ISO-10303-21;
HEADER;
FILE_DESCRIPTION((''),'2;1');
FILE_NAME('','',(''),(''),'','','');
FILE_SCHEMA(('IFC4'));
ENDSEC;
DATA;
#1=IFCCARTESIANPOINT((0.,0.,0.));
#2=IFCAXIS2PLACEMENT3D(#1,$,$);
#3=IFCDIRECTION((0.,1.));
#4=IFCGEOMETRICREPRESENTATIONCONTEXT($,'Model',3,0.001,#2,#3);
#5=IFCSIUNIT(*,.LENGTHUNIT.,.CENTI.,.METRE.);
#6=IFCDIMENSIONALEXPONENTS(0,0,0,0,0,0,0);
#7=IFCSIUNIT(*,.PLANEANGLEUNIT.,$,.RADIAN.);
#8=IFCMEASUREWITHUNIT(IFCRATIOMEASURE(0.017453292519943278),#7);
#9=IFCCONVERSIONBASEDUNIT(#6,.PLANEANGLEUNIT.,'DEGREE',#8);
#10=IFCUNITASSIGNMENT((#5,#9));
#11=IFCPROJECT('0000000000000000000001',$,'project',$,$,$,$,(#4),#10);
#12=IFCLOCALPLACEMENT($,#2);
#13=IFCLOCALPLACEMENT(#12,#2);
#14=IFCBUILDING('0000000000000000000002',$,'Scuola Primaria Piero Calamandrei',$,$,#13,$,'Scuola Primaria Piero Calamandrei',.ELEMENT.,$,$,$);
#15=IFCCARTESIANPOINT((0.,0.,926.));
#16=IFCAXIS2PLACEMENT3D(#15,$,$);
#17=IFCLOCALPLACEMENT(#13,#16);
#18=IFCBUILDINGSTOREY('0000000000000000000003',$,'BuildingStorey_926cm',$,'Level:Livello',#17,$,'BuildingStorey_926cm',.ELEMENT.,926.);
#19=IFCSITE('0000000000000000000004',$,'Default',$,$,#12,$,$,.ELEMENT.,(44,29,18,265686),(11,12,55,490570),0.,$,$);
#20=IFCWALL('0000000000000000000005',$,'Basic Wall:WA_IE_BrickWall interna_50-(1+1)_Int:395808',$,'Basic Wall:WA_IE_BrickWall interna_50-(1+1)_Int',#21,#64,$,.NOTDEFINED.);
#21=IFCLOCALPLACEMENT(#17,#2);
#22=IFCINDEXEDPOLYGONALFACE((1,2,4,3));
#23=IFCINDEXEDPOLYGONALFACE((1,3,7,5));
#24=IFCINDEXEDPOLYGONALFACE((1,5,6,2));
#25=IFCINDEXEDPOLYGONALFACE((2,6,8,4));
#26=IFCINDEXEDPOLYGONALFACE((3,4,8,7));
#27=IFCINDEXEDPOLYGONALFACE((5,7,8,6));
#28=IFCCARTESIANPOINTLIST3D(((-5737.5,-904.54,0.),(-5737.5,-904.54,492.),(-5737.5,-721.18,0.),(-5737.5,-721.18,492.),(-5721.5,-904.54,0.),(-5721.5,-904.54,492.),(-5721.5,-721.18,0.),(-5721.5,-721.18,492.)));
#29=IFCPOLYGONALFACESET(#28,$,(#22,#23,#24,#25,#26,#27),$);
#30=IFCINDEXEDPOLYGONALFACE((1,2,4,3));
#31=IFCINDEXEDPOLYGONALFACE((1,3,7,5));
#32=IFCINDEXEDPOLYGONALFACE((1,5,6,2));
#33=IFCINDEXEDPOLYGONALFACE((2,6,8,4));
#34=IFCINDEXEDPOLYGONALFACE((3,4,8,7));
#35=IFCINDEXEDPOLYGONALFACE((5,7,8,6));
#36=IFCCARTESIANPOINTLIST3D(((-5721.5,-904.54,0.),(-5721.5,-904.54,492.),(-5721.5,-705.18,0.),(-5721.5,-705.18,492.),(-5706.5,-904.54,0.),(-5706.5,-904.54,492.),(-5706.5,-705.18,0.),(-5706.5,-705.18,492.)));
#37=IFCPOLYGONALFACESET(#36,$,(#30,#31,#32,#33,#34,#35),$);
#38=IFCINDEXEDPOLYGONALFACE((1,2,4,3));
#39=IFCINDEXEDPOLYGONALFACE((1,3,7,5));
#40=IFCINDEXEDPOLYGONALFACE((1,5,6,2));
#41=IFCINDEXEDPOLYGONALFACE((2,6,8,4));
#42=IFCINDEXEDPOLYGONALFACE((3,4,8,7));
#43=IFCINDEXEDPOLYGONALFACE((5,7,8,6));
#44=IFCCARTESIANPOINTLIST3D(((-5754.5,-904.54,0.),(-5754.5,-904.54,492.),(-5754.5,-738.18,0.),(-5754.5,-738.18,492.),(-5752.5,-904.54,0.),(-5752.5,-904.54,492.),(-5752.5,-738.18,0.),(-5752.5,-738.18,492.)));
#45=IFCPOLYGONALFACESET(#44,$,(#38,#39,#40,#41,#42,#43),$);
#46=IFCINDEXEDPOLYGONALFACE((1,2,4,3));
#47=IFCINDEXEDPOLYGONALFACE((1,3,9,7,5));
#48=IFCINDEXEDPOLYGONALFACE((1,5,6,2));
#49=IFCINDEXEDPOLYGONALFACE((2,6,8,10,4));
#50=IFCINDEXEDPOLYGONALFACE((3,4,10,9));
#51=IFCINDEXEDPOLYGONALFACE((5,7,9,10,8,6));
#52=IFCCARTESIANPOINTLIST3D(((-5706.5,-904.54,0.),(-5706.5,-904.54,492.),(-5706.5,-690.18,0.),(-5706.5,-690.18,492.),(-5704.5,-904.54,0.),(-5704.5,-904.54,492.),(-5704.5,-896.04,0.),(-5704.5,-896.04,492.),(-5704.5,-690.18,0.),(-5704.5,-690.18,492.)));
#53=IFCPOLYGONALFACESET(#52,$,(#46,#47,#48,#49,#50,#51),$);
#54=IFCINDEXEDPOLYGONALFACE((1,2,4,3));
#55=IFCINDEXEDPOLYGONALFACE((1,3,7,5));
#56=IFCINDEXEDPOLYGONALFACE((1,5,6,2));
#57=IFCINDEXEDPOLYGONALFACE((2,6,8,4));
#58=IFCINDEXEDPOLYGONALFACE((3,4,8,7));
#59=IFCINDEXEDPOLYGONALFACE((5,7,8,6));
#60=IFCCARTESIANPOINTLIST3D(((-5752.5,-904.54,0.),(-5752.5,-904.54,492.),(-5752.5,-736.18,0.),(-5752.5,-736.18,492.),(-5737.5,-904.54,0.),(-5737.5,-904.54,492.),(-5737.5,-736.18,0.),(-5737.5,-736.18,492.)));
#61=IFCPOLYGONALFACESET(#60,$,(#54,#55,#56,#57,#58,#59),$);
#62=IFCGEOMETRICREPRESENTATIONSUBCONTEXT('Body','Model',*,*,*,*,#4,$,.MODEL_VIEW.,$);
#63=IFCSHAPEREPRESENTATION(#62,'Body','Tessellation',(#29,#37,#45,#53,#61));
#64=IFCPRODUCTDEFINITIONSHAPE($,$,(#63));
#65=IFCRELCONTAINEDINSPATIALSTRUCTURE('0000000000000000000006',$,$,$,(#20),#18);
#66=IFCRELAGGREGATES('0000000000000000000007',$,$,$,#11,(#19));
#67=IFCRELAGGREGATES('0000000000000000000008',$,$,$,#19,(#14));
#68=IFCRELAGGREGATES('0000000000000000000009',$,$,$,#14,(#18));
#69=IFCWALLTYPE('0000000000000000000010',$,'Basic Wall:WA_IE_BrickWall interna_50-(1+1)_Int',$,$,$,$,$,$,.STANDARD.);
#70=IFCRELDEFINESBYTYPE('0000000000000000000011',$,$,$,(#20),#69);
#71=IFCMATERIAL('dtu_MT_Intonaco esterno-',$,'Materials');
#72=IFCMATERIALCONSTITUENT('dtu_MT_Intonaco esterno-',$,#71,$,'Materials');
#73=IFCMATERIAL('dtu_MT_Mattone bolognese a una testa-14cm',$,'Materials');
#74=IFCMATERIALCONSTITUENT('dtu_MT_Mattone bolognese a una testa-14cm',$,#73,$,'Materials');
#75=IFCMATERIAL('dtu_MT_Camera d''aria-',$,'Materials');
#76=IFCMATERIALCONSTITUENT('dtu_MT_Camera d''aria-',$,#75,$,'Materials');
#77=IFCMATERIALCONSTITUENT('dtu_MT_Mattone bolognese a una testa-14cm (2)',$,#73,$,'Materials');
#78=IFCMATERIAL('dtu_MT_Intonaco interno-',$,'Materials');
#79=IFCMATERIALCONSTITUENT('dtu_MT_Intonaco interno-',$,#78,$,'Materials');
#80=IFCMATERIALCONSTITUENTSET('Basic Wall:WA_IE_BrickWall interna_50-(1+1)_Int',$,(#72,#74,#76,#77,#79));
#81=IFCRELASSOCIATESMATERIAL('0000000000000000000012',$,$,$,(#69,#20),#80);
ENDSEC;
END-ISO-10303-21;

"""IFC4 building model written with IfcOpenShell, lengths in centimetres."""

from ifc_helpers import new_model, entity, si_unit, converted_unit, direction, frame, origin, place, context, subcontext, project, spatial, indexed_curve, outline, extrude, material, constituent, constituent_set, type_object, element, save


model = new_model("IFC4")

# Units and contexts
model_context = context("Model", 3, precision=0.001, world=origin(), true_north=direction((0.0, 1.0)))
body_context = subcontext(model_context, "Body", "Model", "MODEL_VIEW")
ifc_project = project(units=[si_unit("LENGTHUNIT", "METRE", prefix="CENTI"), converted_unit("PLANEANGLEUNIT", "DEGREE", entity("IfcRatioMeasure", 0.017453292519943278), si_unit("PLANEANGLEUNIT", "RADIAN"), dimensions=[0, 0, 0, 0, 0, 0, 0])], contexts=[model_context])

# Site, building, storey
site_placement = place(None, origin())
site = spatial("IfcSite", under=ifc_project, at=site_placement, Name="Default", CompositionType="ELEMENT", RefLatitude=(44, 29, 18, 265686), RefLongitude=(11, 12, 55, 490570), RefElevation=0.0)
building_placement = place(site_placement, origin())
building = spatial("IfcBuilding", under=site, at=building_placement, Name="Scuola Primaria Piero Calamandrei", LongName="Scuola Primaria Piero Calamandrei", CompositionType="ELEMENT")
storey_placement = place(building_placement, frame((0.0, 0.0, 926.0)))
storey = spatial("IfcBuildingStorey", under=building, at=storey_placement, Name="BuildingStorey_926cm", ObjectType="Level:Livello", LongName="BuildingStorey_926cm", CompositionType="ELEMENT", Elevation=926.0)

# Shared definitions
ifc_material_1 = material(Name="dtu_MT_Mattone bolognese a una testa-14cm", Category="Materials")
ifc_material_2 = material(Name="dtu_MT_Camera d'aria-", Category="Materials")
ifc_material_3 = material(Name="dtu_MT_Intonaco interno-", Category="Materials")

# Shared definitions
ifc_material_4 = material(Name="dtu_MT_Intonaco esterno-", Category="Materials")
ifc_constituent_1 = constituent(ifc_material_4, Name="dtu_MT_Intonaco esterno-", Category="Materials")
ifc_constituent_2 = constituent(ifc_material_1, Name="dtu_MT_Mattone bolognese a una testa-14cm", Category="Materials")
ifc_constituent_3 = constituent(ifc_material_2, Name="dtu_MT_Camera d'aria-", Category="Materials")
ifc_constituent_4 = constituent(ifc_material_1, Name="dtu_MT_Mattone bolognese a una testa-14cm (2)", Category="Materials")
ifc_constituent_5 = constituent(ifc_material_3, Name="dtu_MT_Intonaco interno-", Category="Materials")
ifc_constituent_set_1 = constituent_set(constituents=[ifc_constituent_1, ifc_constituent_2, ifc_constituent_3, ifc_constituent_4, ifc_constituent_5], Name="Basic Wall:WA_IE_BrickWall interna_50-(1+1)_Int")
wall_type_1 = type_object("IfcWallType", Name="Basic Wall:WA_IE_BrickWall interna_50-(1+1)_Int", PredefinedType="STANDARD", material=ifc_constituent_set_1)

# Wall
wall_1_placement = place(storey_placement, frame((-5729.5, -738.18, 0.0), z_axis=(0.0, 0.0, 1.0), x_axis=(0.0, -1.0, 0.0)))
element("IfcWall", 1, at=wall_1_placement, inside=storey, type_object=wall_type_1, material=ifc_constituent_set_1, Name="Basic Wall:WA_IE_BrickWall interna_50-(1+1)_Int:395808", ObjectType="Basic Wall:WA_IE_BrickWall interna_50-(1+1)_Int", PredefinedType="NOTDEFINED", context=body_context, shape_type="SweptSolid", body=[
    extrude(outline(indexed_curve([(-91.68, -8.0), (91.68, -8.0), (91.68, 8.0), (-91.68, 8.0), (-91.68, -8.0)], self_intersect=False)), frame((74.68, 0.0, 0.0)), (0.0, 0.0, 1.0), 492.0),
    extrude(outline(indexed_curve([(-99.68, -7.5), (99.68, -7.5), (99.68, 7.5), (-99.68, 7.5), (-99.68, -7.5)], self_intersect=False)), frame((66.68, 15.5, 0.0)), (0.0, 0.0, 1.0), 492.0),
    extrude(outline(indexed_curve([(-1.0, -83.18), (1.0, -83.18), (1.0, 83.18), (-1.0, 83.18), (-1.0, -83.18)], self_intersect=False)), frame((83.18, -24.0, 0.0), z_axis=(0.0, 0.0, 1.0), x_axis=(0.0, 1.0, 0.0)), (0.0, 0.0, 1.0), 492.0),
    extrude(outline(indexed_curve([(-78.94, -0.8), (126.91, -0.8), (126.91, 1.2), (-87.44, 1.2), (-87.44, -0.8), (-78.94, -0.8)], self_intersect=False)), frame((78.91, 24.2, 0.0), z_axis=(0.0, 0.0, 1.0), x_axis=(-1.0, 0.0, 0.0)), (0.0, 0.0, 1.0), 492.0),
    extrude(outline(indexed_curve([(-84.18, -7.5), (84.18, -7.5), (84.18, 7.5), (-84.18, 7.5), (-84.18, -7.5)], self_intersect=False)), frame((82.18, -15.5, 0.0)), (0.0, 0.0, 1.0), 492.0),
])

save(model, "model.ifc")
